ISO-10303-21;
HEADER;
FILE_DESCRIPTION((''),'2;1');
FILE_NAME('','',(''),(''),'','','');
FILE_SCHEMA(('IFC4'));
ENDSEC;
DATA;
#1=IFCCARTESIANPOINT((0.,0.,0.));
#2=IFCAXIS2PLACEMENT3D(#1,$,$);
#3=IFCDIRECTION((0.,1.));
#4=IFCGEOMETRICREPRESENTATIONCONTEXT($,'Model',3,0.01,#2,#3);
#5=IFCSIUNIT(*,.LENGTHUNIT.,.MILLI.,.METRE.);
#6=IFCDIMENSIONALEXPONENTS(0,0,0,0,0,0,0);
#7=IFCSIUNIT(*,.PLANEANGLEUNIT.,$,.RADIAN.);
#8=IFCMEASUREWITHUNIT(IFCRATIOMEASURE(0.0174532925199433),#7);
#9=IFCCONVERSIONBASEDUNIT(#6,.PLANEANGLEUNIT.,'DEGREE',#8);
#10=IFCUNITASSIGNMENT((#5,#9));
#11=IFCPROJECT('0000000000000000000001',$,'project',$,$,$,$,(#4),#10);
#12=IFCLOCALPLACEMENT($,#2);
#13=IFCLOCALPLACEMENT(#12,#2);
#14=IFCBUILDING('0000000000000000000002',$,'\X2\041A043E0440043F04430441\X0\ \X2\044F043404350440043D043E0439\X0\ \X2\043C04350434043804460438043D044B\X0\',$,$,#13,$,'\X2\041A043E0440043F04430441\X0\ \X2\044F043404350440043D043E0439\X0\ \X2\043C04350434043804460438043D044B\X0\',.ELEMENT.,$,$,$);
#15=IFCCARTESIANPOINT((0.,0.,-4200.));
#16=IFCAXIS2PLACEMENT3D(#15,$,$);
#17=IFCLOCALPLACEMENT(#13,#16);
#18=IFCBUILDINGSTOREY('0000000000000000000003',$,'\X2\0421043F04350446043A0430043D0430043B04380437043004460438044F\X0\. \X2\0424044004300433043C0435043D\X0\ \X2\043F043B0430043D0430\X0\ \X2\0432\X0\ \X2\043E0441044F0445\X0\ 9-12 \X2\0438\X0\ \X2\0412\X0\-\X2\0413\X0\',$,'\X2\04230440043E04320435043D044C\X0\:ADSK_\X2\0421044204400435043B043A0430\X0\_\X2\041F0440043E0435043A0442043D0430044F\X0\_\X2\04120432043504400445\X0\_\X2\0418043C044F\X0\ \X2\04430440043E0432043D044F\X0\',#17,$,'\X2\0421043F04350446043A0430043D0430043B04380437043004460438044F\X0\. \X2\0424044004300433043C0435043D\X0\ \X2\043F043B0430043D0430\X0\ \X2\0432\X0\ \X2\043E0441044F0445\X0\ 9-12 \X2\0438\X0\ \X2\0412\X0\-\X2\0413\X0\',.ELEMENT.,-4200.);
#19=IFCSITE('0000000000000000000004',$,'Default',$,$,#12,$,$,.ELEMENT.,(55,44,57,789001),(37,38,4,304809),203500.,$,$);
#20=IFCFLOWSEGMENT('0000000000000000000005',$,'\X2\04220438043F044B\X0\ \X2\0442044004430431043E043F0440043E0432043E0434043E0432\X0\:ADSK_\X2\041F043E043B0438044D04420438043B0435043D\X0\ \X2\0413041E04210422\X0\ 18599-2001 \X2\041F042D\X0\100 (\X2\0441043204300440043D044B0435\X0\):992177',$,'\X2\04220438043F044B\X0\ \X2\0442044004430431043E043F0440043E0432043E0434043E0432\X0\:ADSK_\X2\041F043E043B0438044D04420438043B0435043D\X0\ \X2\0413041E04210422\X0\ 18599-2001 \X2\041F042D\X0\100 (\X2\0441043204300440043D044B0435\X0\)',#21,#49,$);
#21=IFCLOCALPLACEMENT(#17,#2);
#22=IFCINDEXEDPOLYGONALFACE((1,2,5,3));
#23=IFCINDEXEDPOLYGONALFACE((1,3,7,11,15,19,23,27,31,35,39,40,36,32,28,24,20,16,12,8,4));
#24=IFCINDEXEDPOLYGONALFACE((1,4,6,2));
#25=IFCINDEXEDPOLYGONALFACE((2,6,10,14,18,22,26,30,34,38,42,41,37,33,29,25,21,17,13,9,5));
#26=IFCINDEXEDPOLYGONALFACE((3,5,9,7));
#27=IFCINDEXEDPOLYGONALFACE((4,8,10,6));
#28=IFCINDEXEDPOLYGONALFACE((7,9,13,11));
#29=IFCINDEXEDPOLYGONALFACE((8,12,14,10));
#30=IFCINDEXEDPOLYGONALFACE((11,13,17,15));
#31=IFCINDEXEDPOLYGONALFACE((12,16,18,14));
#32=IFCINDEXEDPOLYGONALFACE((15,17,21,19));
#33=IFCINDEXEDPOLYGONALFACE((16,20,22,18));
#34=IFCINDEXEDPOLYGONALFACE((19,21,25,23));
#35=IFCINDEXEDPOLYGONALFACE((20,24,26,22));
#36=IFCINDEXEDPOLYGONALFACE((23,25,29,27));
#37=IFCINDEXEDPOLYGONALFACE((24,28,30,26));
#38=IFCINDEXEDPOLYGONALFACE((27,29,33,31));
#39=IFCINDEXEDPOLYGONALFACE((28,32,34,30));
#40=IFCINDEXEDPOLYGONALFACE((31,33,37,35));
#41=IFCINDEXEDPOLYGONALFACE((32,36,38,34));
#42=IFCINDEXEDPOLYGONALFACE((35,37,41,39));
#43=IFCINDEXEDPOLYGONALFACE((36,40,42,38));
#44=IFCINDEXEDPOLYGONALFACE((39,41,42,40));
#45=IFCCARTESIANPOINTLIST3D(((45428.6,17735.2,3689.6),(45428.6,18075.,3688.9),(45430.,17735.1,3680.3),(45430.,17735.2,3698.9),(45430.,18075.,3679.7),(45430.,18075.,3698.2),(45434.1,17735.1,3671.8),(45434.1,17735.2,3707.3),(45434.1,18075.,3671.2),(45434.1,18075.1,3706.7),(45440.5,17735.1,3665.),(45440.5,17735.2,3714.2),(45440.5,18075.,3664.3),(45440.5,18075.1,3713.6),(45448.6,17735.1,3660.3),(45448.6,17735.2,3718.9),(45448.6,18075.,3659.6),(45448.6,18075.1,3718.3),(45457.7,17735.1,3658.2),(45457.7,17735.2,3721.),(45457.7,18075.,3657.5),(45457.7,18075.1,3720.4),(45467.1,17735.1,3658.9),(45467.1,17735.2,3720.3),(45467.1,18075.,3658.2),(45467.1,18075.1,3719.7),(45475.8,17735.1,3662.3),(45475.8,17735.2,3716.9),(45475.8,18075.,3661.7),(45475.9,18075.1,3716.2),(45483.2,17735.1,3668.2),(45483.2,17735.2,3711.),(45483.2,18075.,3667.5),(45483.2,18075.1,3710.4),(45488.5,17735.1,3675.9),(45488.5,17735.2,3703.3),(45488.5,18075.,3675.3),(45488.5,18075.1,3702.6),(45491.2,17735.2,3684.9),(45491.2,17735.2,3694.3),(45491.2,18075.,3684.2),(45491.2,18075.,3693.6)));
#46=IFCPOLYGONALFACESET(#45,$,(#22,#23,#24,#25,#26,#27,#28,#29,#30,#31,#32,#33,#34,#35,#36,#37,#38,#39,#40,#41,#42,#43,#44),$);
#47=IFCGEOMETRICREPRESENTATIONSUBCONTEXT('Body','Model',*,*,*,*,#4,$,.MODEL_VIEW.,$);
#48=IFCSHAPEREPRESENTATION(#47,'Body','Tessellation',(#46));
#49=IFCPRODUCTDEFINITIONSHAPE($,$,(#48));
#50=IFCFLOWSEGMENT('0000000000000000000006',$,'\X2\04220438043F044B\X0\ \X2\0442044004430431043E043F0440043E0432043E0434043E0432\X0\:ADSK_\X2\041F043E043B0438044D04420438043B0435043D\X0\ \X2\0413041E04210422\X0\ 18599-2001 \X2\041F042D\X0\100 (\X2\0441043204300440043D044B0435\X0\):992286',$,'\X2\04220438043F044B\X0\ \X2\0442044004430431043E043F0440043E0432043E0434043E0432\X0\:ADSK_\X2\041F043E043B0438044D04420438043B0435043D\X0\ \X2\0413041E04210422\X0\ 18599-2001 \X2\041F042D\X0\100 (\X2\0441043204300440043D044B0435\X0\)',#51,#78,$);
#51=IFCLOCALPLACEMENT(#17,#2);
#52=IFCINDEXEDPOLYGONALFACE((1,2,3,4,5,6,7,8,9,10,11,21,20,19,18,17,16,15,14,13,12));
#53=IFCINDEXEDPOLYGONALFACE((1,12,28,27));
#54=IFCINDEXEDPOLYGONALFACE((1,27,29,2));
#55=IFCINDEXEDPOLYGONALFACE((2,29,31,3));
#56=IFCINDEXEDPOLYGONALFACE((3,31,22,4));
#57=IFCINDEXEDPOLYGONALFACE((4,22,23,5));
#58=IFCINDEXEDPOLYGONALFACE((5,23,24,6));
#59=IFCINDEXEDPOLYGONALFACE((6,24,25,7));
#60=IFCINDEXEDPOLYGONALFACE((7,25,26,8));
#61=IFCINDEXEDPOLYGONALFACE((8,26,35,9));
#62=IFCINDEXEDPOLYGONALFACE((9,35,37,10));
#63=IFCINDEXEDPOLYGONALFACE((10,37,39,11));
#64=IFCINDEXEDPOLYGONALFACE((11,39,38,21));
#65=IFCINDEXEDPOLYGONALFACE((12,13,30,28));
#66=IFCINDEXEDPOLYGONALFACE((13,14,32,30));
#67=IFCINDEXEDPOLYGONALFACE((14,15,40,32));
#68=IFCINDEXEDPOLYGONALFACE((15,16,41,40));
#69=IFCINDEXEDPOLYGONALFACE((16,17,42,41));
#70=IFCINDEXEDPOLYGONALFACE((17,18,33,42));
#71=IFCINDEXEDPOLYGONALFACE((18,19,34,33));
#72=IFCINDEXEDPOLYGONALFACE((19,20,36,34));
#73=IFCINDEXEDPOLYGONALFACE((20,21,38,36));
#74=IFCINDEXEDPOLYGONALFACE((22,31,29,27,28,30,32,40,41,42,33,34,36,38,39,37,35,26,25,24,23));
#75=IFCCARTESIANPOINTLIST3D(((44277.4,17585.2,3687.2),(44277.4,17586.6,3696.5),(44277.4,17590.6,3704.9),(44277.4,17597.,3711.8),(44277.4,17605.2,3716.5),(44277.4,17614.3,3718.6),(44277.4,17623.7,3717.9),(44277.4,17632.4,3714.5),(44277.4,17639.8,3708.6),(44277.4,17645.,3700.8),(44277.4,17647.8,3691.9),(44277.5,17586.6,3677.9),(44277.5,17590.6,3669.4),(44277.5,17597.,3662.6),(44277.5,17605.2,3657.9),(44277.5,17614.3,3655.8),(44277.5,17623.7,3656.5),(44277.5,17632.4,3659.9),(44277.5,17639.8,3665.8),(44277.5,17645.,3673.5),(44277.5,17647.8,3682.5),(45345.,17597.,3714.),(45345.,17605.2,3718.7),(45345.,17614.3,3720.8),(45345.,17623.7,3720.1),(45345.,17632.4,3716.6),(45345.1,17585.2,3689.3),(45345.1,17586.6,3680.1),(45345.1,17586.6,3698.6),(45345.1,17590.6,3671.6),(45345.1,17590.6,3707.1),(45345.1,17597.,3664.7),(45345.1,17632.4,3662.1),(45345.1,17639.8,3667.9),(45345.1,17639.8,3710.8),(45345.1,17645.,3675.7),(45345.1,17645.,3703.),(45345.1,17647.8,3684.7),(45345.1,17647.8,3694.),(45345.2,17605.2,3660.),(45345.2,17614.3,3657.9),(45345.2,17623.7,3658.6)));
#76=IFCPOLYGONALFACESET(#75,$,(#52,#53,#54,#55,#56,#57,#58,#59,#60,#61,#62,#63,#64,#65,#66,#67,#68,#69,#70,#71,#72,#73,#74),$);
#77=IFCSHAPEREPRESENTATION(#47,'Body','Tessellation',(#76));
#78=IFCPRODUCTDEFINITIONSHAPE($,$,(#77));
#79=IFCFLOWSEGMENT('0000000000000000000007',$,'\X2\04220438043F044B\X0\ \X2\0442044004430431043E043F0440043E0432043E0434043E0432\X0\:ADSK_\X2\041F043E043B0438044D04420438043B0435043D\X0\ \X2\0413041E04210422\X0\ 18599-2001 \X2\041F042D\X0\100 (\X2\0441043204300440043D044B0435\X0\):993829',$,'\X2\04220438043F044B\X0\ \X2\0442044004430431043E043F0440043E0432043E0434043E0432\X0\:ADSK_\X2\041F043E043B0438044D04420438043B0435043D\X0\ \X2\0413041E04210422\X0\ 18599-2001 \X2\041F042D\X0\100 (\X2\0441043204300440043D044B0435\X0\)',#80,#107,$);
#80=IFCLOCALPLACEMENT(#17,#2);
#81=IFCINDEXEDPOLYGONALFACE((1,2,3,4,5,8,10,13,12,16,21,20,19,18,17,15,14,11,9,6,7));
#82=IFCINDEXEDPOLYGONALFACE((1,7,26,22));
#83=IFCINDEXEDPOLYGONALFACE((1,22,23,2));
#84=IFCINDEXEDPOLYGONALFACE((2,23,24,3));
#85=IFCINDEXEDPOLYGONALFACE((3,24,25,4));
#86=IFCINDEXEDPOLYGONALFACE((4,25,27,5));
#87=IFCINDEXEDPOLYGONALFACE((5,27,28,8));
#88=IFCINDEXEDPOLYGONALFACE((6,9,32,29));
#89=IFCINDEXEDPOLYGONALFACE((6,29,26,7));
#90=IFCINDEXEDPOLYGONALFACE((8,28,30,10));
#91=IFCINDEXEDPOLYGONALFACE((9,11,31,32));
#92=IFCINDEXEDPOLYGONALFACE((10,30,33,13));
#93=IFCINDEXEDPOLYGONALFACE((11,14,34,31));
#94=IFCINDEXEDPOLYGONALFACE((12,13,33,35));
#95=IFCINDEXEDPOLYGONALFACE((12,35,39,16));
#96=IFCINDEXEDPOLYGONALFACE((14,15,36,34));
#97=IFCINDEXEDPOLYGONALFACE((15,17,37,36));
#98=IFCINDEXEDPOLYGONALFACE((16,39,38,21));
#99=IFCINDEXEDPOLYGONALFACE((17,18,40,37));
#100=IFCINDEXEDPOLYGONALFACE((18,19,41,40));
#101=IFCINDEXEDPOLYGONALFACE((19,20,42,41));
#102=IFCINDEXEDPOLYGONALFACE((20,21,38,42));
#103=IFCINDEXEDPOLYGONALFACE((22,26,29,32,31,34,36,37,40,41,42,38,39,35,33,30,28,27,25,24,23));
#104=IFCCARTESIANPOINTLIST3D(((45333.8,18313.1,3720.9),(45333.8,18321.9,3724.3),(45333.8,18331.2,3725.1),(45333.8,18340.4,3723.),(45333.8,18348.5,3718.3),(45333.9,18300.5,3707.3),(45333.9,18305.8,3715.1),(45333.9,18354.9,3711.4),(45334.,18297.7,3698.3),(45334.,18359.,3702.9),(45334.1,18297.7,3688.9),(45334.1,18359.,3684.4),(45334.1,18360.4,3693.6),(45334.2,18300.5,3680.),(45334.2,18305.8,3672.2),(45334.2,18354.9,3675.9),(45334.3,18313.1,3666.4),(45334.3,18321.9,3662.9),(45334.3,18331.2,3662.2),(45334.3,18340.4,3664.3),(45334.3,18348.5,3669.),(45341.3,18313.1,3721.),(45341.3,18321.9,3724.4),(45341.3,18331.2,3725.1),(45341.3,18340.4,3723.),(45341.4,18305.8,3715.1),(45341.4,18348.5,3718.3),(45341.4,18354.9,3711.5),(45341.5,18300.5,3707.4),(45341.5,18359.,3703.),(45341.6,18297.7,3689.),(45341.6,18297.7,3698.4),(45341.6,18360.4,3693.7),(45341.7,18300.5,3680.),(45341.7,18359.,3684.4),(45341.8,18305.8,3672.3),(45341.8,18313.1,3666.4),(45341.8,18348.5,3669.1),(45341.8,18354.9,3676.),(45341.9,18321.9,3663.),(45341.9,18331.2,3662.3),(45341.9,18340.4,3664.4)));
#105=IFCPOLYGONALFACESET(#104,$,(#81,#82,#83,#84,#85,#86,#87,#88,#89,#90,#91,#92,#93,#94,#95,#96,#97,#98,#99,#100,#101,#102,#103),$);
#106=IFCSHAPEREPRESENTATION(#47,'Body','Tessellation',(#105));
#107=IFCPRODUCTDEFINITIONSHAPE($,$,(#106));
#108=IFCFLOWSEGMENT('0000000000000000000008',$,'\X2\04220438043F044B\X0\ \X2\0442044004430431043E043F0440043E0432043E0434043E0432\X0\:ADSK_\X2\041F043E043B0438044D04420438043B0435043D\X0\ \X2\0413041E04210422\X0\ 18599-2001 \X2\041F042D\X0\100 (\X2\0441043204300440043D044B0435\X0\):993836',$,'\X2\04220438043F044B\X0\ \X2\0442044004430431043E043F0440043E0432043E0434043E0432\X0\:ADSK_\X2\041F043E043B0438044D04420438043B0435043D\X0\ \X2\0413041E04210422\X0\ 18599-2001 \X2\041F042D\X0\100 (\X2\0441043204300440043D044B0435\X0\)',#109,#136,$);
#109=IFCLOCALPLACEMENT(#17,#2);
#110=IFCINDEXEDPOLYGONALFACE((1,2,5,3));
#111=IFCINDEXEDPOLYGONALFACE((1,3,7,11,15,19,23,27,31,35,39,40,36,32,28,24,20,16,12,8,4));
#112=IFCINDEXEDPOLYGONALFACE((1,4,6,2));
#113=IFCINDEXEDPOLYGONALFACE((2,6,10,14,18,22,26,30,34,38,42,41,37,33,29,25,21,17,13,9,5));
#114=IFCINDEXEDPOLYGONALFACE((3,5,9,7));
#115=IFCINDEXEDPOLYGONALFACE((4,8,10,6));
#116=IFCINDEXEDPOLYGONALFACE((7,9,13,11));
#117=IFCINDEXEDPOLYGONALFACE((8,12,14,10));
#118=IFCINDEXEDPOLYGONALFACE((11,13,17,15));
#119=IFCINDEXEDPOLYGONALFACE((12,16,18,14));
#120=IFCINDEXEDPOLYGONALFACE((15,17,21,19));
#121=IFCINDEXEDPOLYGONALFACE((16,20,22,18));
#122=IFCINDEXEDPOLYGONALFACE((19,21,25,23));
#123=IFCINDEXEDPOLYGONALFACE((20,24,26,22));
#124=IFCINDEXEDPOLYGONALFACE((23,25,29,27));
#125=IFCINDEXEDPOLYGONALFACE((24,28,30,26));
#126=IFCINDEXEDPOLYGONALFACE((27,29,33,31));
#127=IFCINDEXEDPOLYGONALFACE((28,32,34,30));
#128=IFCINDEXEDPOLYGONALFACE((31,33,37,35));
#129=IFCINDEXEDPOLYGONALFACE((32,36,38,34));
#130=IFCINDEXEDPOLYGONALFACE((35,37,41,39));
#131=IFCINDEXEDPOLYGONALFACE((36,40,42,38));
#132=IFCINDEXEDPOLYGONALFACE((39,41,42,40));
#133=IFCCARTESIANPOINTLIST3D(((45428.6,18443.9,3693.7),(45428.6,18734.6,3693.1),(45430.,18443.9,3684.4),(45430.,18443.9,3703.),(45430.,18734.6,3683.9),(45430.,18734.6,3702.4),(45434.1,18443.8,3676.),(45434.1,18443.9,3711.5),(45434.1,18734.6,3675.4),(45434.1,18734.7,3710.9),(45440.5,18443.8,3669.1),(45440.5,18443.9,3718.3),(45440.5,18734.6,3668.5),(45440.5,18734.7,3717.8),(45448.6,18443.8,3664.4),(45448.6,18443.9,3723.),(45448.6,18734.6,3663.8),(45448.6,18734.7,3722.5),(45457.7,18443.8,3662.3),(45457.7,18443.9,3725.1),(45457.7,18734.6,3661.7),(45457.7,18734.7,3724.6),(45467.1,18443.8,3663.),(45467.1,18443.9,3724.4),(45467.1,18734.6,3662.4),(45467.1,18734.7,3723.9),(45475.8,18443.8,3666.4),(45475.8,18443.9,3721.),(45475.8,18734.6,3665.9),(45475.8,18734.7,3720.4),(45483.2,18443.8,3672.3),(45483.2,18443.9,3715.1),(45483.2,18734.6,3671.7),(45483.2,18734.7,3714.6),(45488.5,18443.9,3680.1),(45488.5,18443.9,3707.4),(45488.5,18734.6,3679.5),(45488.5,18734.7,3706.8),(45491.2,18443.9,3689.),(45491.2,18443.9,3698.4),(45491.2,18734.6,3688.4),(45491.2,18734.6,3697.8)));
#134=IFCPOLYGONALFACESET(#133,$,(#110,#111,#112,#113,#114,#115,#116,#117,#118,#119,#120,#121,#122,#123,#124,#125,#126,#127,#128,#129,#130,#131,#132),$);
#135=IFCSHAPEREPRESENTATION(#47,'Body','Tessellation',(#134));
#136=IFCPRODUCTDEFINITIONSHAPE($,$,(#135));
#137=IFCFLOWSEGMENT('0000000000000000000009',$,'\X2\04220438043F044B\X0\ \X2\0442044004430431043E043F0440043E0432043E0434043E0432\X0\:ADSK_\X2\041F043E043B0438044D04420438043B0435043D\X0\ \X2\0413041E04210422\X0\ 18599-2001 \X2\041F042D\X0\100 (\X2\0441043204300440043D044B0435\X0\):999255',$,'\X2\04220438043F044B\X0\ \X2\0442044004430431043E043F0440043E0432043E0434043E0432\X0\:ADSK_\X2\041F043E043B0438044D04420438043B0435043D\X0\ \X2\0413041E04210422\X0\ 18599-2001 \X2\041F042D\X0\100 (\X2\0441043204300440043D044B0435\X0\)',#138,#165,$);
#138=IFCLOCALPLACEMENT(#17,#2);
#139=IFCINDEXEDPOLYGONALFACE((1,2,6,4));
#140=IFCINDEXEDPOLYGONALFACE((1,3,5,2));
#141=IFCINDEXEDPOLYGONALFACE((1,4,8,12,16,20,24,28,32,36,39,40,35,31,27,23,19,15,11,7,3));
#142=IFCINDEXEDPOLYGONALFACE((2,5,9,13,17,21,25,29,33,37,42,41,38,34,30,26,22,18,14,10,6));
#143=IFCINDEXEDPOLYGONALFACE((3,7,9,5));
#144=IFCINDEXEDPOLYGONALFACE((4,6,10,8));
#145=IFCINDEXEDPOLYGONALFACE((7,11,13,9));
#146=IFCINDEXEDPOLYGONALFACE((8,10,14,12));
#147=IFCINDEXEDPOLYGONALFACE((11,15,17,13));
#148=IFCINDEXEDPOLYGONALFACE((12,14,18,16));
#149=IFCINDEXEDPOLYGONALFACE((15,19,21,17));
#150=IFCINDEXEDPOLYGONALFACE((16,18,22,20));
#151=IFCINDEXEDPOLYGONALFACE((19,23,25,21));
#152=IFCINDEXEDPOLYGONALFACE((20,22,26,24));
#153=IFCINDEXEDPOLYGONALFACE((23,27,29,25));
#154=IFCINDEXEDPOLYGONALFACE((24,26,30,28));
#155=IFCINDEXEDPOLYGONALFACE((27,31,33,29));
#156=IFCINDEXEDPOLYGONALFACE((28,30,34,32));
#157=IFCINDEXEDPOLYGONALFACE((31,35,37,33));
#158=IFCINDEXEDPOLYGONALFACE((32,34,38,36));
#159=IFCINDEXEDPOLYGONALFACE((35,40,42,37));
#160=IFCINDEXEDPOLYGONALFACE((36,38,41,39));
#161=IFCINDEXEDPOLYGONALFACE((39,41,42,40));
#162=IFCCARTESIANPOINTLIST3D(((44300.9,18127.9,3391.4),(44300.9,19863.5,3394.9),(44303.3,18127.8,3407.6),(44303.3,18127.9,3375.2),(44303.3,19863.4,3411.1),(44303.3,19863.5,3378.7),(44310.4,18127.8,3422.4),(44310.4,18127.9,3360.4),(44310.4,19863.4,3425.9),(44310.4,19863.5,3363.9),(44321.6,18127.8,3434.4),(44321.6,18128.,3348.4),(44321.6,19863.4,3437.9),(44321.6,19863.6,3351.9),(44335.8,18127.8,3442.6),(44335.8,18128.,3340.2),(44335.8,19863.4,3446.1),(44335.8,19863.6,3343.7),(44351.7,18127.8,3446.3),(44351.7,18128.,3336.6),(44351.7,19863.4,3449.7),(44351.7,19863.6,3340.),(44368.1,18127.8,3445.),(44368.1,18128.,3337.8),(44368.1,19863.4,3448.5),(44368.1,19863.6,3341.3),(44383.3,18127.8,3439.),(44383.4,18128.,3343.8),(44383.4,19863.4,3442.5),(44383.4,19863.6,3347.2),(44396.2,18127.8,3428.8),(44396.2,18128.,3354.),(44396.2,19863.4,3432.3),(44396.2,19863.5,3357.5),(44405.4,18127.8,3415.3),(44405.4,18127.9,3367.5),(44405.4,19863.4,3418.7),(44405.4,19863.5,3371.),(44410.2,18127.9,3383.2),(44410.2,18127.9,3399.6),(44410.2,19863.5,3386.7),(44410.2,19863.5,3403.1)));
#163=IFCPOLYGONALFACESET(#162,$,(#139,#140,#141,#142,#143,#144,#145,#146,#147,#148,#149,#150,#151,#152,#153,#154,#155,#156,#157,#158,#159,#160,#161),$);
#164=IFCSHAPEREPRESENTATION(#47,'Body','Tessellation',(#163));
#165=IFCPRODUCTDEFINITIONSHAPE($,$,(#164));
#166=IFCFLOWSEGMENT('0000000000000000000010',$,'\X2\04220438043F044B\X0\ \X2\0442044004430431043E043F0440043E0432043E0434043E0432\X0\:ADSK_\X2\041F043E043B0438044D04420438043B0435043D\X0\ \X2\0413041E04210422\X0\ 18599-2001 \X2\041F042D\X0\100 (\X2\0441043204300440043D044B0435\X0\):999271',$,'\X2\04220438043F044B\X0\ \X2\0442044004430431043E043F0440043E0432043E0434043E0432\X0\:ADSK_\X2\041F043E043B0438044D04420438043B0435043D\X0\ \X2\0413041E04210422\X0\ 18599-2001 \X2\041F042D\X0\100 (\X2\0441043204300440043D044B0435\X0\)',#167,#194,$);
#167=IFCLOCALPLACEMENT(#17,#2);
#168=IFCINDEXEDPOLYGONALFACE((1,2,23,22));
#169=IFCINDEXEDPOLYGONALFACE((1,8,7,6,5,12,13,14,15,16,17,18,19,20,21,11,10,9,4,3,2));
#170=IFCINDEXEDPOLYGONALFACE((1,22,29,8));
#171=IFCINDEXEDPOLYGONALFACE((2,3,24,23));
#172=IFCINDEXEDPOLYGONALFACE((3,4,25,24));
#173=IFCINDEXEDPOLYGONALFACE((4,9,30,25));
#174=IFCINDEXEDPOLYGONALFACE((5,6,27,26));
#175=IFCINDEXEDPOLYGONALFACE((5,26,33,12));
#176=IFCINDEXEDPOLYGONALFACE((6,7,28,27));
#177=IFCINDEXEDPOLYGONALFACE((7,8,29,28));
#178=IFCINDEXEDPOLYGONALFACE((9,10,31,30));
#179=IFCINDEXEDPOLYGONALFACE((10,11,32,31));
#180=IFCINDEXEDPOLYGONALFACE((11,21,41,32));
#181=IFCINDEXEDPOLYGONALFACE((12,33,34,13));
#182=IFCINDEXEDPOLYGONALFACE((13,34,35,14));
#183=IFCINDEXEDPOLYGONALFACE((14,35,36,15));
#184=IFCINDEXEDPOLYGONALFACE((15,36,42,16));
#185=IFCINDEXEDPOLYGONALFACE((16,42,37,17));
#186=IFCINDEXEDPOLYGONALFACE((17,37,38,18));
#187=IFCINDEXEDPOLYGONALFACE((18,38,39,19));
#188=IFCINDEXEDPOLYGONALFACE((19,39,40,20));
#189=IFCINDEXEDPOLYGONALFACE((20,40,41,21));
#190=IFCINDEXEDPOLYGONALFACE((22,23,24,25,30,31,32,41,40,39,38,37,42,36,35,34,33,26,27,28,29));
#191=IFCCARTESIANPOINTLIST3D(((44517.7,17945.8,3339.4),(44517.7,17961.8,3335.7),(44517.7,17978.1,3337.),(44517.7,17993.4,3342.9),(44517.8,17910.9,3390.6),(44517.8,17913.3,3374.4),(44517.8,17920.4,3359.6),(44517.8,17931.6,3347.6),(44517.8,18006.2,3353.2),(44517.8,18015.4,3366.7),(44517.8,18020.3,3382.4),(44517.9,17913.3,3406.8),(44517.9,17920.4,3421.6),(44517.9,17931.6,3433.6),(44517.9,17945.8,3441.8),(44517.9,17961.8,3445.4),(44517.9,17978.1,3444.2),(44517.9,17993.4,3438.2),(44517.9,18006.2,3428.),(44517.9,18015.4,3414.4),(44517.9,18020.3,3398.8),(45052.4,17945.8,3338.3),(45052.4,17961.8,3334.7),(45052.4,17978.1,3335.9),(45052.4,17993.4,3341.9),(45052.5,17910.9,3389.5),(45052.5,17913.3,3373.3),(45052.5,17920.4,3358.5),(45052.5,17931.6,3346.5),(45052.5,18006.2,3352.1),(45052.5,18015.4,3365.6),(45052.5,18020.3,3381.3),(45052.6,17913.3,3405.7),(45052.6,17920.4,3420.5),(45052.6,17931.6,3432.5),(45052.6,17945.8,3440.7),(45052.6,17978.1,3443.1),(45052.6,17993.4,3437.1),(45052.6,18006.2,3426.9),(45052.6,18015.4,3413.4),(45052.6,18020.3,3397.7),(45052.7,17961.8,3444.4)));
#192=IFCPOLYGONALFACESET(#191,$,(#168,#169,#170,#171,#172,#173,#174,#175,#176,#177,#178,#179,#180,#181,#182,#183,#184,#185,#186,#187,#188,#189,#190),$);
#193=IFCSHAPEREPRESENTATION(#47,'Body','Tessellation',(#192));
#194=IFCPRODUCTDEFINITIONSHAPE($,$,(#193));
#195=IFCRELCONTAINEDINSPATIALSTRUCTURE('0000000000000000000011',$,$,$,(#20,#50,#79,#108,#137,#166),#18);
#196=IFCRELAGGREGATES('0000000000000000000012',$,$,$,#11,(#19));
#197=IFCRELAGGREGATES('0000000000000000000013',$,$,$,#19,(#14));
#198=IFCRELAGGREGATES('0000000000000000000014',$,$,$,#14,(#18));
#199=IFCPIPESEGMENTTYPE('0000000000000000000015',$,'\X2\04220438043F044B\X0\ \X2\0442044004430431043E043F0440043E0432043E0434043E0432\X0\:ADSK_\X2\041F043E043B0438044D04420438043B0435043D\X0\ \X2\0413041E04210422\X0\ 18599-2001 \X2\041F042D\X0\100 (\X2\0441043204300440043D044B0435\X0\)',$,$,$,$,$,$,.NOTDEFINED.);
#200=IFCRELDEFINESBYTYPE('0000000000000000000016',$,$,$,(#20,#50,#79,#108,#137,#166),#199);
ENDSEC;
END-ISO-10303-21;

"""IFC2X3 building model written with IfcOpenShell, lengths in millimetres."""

from ifc_helpers import new_model, entity, si_unit, converted_unit, direction, frame, origin, origin_2d_with_axis, place, context, subcontext, project, spatial, circle, extrude, type_object, element, save


model = new_model("IFC2X3")

# Units and contexts
model_context = context("Model", 3, precision=0.01, world=origin(), true_north=direction((0.0, 1.0)))
body_context = subcontext(model_context, "Body", "Model", "MODEL_VIEW")
ifc_project = project(units=[si_unit("LENGTHUNIT", "METRE", prefix="MILLI"), converted_unit("PLANEANGLEUNIT", "DEGREE", entity("IfcRatioMeasure", 0.0174532925199433), si_unit("PLANEANGLEUNIT", "RADIAN"), dimensions=[0, 0, 0, 0, 0, 0, 0])], contexts=[model_context])

# Site, building, storey
site_placement = place(None, origin())
site = spatial("IfcSite", under=ifc_project, at=site_placement, Name="Default", CompositionType="ELEMENT", RefLatitude=(55, 44, 57, 789001), RefLongitude=(37, 38, 4, 304809), RefElevation=203500.0)
building_placement = place(site_placement, origin())
building = spatial("IfcBuilding", under=site, at=building_placement, Name="Корпус ядерной медицины", LongName="Корпус ядерной медицины", CompositionType="ELEMENT")
storey_placement = place(building_placement, frame((0.0, 0.0, -4200.0)))
storey = spatial("IfcBuildingStorey", under=building, at=storey_placement, Name="Спецканализация. Фрагмен плана в осях 9-12 и В-Г", ObjectType="Уровень:ADSK_Стрелка_Проектная_Вверх_Имя уровня", LongName="Спецканализация. Фрагмен плана в осях 9-12 и В-Г", CompositionType="ELEMENT", Elevation=-4200.0)

# Flow segments
pipe_segment_type = type_object("IfcPipeSegmentType", Name="Типы трубопроводов:ADSK_Полиэтилен ГОСТ 18599-2001 ПЭ100 (сварные)", PredefinedType="NOTDEFINED")
flow_segment_1_placement = place(storey_placement, frame((45427.0, 17735.1, 3655.8)))
element("IfcFlowSegment", 1, at=flow_segment_1_placement, inside=storey, type_object=pipe_segment_type, Name="Типы трубопроводов:ADSK_Полиэтилен ГОСТ 18599-2001 ПЭ100 (сварные):992177", ObjectType="Типы трубопроводов:ADSK_Полиэтилен ГОСТ 18599-2001 ПЭ100 (сварные)", context=body_context, shape_type="SweptSolid", body=[
    extrude(circle(Radius=31.5, at=origin_2d_with_axis()), frame((33.1, 339.9, 33.1), z_axis=(-0.000004, -0.999998, 0.0019), x_axis=(-1.0, 0.000004, 0.0)), (0.0, 0.0, 1.0), 339.9),
])
flow_segment_2_placement = place(storey_placement, frame((44277.4, 17583.6, 3654.1)))
element("IfcFlowSegment", 2, at=flow_segment_2_placement, inside=storey, type_object=pipe_segment_type, Name="Типы трубопроводов:ADSK_Полиэтилен ГОСТ 18599-2001 ПЭ100 (сварные):992286", ObjectType="Типы трубопроводов:ADSK_Полиэтилен ГОСТ 18599-2001 ПЭ100 (сварные)", context=body_context, shape_type="SweptSolid", body=[
    extrude(circle(Radius=31.5, at=origin_2d_with_axis()), frame((0.1, 33.1, 33.1), z_axis=(0.999998, 0.0, 0.002028), x_axis=(0.0, -1.0, 0.0)), (0.0, 0.0, 1.0), 1067.6),
])
flow_segment_3_placement = place(storey_placement, frame((45332.2, 18295.8, 3660.6)))
element("IfcFlowSegment", 3, at=flow_segment_3_placement, inside=storey, type_object=pipe_segment_type, Name="Типы трубопроводов:ADSK_Полиэтилен ГОСТ 18599-2001 ПЭ100 (сварные):993829", ObjectType="Типы трубопроводов:ADSK_Полиэтилен ГОСТ 18599-2001 ПЭ100 (сварные)", context=body_context, shape_type="SweptSolid", body=[
    extrude(circle(Radius=31.5, at=origin_2d_with_axis()), frame((1.9, 33.1, 33.1), z_axis=(0.99996, -0.000002, 0.008936), x_axis=(0.000002, 1.0, 0.0)), (0.0, 0.0, 1.0), 7.5),
])
flow_segment_4_placement = place(storey_placement, frame((45427.0, 18443.8, 3660.0)))
element("IfcFlowSegment", 4, at=flow_segment_4_placement, inside=storey, type_object=pipe_segment_type, Name="Типы трубопроводов:ADSK_Полиэтилен ГОСТ 18599-2001 ПЭ100 (сварные):993836", ObjectType="Типы трубопроводов:ADSK_Полиэтилен ГОСТ 18599-2001 ПЭ100 (сварные)", context=body_context, shape_type="SweptSolid", body=[
    extrude(circle(Radius=31.5, at=origin_2d_with_axis()), frame((33.1, 290.8, 33.1), z_axis=(0.0, -0.999998, 0.002), x_axis=(-1.0, 0.0, 0.0)), (0.0, 0.0, 1.0), 290.7),
])
flow_segment_5_placement = place(storey_placement, frame((44299.2, 18127.8, 3334.8)))
element("IfcFlowSegment", 5, at=flow_segment_5_placement, inside=storey, type_object=pipe_segment_type, Name="Типы трубопроводов:ADSK_Полиэтилен ГОСТ 18599-2001 ПЭ100 (сварные):999255", ObjectType="Типы трубопроводов:ADSK_Полиэтилен ГОСТ 18599-2001 ПЭ100 (сварные)", context=body_context, shape_type="SweptSolid", body=[
    extrude(circle(Radius=55.0, at=origin_2d_with_axis()), frame((56.6, 0.1, 56.6), z_axis=(0.0, 0.999998, 0.002), x_axis=(-1.0, 0.0, 0.0)), (0.0, 0.0, 1.0), 1735.6),
])
flow_segment_6_placement = place(storey_placement, frame((44517.7, 17909.3, 3332.9)))
element("IfcFlowSegment", 6, at=flow_segment_6_placement, inside=storey, type_object=pipe_segment_type, Name="Типы трубопроводов:ADSK_Полиэтилен ГОСТ 18599-2001 ПЭ100 (сварные):999271", ObjectType="Типы трубопроводов:ADSK_Полиэтилен ГОСТ 18599-2001 ПЭ100 (сварные)", context=body_context, shape_type="SweptSolid", body=[
    extrude(circle(Radius=55.0, at=origin_2d_with_axis()), frame((0.1, 56.6, 57.7), z_axis=(0.999998, 0.000005, -0.002003), x_axis=(0.000005, -1.0, 0.0)), (0.0, 0.0, 1.0), 534.7),
])

save(model, "model.ifc")
